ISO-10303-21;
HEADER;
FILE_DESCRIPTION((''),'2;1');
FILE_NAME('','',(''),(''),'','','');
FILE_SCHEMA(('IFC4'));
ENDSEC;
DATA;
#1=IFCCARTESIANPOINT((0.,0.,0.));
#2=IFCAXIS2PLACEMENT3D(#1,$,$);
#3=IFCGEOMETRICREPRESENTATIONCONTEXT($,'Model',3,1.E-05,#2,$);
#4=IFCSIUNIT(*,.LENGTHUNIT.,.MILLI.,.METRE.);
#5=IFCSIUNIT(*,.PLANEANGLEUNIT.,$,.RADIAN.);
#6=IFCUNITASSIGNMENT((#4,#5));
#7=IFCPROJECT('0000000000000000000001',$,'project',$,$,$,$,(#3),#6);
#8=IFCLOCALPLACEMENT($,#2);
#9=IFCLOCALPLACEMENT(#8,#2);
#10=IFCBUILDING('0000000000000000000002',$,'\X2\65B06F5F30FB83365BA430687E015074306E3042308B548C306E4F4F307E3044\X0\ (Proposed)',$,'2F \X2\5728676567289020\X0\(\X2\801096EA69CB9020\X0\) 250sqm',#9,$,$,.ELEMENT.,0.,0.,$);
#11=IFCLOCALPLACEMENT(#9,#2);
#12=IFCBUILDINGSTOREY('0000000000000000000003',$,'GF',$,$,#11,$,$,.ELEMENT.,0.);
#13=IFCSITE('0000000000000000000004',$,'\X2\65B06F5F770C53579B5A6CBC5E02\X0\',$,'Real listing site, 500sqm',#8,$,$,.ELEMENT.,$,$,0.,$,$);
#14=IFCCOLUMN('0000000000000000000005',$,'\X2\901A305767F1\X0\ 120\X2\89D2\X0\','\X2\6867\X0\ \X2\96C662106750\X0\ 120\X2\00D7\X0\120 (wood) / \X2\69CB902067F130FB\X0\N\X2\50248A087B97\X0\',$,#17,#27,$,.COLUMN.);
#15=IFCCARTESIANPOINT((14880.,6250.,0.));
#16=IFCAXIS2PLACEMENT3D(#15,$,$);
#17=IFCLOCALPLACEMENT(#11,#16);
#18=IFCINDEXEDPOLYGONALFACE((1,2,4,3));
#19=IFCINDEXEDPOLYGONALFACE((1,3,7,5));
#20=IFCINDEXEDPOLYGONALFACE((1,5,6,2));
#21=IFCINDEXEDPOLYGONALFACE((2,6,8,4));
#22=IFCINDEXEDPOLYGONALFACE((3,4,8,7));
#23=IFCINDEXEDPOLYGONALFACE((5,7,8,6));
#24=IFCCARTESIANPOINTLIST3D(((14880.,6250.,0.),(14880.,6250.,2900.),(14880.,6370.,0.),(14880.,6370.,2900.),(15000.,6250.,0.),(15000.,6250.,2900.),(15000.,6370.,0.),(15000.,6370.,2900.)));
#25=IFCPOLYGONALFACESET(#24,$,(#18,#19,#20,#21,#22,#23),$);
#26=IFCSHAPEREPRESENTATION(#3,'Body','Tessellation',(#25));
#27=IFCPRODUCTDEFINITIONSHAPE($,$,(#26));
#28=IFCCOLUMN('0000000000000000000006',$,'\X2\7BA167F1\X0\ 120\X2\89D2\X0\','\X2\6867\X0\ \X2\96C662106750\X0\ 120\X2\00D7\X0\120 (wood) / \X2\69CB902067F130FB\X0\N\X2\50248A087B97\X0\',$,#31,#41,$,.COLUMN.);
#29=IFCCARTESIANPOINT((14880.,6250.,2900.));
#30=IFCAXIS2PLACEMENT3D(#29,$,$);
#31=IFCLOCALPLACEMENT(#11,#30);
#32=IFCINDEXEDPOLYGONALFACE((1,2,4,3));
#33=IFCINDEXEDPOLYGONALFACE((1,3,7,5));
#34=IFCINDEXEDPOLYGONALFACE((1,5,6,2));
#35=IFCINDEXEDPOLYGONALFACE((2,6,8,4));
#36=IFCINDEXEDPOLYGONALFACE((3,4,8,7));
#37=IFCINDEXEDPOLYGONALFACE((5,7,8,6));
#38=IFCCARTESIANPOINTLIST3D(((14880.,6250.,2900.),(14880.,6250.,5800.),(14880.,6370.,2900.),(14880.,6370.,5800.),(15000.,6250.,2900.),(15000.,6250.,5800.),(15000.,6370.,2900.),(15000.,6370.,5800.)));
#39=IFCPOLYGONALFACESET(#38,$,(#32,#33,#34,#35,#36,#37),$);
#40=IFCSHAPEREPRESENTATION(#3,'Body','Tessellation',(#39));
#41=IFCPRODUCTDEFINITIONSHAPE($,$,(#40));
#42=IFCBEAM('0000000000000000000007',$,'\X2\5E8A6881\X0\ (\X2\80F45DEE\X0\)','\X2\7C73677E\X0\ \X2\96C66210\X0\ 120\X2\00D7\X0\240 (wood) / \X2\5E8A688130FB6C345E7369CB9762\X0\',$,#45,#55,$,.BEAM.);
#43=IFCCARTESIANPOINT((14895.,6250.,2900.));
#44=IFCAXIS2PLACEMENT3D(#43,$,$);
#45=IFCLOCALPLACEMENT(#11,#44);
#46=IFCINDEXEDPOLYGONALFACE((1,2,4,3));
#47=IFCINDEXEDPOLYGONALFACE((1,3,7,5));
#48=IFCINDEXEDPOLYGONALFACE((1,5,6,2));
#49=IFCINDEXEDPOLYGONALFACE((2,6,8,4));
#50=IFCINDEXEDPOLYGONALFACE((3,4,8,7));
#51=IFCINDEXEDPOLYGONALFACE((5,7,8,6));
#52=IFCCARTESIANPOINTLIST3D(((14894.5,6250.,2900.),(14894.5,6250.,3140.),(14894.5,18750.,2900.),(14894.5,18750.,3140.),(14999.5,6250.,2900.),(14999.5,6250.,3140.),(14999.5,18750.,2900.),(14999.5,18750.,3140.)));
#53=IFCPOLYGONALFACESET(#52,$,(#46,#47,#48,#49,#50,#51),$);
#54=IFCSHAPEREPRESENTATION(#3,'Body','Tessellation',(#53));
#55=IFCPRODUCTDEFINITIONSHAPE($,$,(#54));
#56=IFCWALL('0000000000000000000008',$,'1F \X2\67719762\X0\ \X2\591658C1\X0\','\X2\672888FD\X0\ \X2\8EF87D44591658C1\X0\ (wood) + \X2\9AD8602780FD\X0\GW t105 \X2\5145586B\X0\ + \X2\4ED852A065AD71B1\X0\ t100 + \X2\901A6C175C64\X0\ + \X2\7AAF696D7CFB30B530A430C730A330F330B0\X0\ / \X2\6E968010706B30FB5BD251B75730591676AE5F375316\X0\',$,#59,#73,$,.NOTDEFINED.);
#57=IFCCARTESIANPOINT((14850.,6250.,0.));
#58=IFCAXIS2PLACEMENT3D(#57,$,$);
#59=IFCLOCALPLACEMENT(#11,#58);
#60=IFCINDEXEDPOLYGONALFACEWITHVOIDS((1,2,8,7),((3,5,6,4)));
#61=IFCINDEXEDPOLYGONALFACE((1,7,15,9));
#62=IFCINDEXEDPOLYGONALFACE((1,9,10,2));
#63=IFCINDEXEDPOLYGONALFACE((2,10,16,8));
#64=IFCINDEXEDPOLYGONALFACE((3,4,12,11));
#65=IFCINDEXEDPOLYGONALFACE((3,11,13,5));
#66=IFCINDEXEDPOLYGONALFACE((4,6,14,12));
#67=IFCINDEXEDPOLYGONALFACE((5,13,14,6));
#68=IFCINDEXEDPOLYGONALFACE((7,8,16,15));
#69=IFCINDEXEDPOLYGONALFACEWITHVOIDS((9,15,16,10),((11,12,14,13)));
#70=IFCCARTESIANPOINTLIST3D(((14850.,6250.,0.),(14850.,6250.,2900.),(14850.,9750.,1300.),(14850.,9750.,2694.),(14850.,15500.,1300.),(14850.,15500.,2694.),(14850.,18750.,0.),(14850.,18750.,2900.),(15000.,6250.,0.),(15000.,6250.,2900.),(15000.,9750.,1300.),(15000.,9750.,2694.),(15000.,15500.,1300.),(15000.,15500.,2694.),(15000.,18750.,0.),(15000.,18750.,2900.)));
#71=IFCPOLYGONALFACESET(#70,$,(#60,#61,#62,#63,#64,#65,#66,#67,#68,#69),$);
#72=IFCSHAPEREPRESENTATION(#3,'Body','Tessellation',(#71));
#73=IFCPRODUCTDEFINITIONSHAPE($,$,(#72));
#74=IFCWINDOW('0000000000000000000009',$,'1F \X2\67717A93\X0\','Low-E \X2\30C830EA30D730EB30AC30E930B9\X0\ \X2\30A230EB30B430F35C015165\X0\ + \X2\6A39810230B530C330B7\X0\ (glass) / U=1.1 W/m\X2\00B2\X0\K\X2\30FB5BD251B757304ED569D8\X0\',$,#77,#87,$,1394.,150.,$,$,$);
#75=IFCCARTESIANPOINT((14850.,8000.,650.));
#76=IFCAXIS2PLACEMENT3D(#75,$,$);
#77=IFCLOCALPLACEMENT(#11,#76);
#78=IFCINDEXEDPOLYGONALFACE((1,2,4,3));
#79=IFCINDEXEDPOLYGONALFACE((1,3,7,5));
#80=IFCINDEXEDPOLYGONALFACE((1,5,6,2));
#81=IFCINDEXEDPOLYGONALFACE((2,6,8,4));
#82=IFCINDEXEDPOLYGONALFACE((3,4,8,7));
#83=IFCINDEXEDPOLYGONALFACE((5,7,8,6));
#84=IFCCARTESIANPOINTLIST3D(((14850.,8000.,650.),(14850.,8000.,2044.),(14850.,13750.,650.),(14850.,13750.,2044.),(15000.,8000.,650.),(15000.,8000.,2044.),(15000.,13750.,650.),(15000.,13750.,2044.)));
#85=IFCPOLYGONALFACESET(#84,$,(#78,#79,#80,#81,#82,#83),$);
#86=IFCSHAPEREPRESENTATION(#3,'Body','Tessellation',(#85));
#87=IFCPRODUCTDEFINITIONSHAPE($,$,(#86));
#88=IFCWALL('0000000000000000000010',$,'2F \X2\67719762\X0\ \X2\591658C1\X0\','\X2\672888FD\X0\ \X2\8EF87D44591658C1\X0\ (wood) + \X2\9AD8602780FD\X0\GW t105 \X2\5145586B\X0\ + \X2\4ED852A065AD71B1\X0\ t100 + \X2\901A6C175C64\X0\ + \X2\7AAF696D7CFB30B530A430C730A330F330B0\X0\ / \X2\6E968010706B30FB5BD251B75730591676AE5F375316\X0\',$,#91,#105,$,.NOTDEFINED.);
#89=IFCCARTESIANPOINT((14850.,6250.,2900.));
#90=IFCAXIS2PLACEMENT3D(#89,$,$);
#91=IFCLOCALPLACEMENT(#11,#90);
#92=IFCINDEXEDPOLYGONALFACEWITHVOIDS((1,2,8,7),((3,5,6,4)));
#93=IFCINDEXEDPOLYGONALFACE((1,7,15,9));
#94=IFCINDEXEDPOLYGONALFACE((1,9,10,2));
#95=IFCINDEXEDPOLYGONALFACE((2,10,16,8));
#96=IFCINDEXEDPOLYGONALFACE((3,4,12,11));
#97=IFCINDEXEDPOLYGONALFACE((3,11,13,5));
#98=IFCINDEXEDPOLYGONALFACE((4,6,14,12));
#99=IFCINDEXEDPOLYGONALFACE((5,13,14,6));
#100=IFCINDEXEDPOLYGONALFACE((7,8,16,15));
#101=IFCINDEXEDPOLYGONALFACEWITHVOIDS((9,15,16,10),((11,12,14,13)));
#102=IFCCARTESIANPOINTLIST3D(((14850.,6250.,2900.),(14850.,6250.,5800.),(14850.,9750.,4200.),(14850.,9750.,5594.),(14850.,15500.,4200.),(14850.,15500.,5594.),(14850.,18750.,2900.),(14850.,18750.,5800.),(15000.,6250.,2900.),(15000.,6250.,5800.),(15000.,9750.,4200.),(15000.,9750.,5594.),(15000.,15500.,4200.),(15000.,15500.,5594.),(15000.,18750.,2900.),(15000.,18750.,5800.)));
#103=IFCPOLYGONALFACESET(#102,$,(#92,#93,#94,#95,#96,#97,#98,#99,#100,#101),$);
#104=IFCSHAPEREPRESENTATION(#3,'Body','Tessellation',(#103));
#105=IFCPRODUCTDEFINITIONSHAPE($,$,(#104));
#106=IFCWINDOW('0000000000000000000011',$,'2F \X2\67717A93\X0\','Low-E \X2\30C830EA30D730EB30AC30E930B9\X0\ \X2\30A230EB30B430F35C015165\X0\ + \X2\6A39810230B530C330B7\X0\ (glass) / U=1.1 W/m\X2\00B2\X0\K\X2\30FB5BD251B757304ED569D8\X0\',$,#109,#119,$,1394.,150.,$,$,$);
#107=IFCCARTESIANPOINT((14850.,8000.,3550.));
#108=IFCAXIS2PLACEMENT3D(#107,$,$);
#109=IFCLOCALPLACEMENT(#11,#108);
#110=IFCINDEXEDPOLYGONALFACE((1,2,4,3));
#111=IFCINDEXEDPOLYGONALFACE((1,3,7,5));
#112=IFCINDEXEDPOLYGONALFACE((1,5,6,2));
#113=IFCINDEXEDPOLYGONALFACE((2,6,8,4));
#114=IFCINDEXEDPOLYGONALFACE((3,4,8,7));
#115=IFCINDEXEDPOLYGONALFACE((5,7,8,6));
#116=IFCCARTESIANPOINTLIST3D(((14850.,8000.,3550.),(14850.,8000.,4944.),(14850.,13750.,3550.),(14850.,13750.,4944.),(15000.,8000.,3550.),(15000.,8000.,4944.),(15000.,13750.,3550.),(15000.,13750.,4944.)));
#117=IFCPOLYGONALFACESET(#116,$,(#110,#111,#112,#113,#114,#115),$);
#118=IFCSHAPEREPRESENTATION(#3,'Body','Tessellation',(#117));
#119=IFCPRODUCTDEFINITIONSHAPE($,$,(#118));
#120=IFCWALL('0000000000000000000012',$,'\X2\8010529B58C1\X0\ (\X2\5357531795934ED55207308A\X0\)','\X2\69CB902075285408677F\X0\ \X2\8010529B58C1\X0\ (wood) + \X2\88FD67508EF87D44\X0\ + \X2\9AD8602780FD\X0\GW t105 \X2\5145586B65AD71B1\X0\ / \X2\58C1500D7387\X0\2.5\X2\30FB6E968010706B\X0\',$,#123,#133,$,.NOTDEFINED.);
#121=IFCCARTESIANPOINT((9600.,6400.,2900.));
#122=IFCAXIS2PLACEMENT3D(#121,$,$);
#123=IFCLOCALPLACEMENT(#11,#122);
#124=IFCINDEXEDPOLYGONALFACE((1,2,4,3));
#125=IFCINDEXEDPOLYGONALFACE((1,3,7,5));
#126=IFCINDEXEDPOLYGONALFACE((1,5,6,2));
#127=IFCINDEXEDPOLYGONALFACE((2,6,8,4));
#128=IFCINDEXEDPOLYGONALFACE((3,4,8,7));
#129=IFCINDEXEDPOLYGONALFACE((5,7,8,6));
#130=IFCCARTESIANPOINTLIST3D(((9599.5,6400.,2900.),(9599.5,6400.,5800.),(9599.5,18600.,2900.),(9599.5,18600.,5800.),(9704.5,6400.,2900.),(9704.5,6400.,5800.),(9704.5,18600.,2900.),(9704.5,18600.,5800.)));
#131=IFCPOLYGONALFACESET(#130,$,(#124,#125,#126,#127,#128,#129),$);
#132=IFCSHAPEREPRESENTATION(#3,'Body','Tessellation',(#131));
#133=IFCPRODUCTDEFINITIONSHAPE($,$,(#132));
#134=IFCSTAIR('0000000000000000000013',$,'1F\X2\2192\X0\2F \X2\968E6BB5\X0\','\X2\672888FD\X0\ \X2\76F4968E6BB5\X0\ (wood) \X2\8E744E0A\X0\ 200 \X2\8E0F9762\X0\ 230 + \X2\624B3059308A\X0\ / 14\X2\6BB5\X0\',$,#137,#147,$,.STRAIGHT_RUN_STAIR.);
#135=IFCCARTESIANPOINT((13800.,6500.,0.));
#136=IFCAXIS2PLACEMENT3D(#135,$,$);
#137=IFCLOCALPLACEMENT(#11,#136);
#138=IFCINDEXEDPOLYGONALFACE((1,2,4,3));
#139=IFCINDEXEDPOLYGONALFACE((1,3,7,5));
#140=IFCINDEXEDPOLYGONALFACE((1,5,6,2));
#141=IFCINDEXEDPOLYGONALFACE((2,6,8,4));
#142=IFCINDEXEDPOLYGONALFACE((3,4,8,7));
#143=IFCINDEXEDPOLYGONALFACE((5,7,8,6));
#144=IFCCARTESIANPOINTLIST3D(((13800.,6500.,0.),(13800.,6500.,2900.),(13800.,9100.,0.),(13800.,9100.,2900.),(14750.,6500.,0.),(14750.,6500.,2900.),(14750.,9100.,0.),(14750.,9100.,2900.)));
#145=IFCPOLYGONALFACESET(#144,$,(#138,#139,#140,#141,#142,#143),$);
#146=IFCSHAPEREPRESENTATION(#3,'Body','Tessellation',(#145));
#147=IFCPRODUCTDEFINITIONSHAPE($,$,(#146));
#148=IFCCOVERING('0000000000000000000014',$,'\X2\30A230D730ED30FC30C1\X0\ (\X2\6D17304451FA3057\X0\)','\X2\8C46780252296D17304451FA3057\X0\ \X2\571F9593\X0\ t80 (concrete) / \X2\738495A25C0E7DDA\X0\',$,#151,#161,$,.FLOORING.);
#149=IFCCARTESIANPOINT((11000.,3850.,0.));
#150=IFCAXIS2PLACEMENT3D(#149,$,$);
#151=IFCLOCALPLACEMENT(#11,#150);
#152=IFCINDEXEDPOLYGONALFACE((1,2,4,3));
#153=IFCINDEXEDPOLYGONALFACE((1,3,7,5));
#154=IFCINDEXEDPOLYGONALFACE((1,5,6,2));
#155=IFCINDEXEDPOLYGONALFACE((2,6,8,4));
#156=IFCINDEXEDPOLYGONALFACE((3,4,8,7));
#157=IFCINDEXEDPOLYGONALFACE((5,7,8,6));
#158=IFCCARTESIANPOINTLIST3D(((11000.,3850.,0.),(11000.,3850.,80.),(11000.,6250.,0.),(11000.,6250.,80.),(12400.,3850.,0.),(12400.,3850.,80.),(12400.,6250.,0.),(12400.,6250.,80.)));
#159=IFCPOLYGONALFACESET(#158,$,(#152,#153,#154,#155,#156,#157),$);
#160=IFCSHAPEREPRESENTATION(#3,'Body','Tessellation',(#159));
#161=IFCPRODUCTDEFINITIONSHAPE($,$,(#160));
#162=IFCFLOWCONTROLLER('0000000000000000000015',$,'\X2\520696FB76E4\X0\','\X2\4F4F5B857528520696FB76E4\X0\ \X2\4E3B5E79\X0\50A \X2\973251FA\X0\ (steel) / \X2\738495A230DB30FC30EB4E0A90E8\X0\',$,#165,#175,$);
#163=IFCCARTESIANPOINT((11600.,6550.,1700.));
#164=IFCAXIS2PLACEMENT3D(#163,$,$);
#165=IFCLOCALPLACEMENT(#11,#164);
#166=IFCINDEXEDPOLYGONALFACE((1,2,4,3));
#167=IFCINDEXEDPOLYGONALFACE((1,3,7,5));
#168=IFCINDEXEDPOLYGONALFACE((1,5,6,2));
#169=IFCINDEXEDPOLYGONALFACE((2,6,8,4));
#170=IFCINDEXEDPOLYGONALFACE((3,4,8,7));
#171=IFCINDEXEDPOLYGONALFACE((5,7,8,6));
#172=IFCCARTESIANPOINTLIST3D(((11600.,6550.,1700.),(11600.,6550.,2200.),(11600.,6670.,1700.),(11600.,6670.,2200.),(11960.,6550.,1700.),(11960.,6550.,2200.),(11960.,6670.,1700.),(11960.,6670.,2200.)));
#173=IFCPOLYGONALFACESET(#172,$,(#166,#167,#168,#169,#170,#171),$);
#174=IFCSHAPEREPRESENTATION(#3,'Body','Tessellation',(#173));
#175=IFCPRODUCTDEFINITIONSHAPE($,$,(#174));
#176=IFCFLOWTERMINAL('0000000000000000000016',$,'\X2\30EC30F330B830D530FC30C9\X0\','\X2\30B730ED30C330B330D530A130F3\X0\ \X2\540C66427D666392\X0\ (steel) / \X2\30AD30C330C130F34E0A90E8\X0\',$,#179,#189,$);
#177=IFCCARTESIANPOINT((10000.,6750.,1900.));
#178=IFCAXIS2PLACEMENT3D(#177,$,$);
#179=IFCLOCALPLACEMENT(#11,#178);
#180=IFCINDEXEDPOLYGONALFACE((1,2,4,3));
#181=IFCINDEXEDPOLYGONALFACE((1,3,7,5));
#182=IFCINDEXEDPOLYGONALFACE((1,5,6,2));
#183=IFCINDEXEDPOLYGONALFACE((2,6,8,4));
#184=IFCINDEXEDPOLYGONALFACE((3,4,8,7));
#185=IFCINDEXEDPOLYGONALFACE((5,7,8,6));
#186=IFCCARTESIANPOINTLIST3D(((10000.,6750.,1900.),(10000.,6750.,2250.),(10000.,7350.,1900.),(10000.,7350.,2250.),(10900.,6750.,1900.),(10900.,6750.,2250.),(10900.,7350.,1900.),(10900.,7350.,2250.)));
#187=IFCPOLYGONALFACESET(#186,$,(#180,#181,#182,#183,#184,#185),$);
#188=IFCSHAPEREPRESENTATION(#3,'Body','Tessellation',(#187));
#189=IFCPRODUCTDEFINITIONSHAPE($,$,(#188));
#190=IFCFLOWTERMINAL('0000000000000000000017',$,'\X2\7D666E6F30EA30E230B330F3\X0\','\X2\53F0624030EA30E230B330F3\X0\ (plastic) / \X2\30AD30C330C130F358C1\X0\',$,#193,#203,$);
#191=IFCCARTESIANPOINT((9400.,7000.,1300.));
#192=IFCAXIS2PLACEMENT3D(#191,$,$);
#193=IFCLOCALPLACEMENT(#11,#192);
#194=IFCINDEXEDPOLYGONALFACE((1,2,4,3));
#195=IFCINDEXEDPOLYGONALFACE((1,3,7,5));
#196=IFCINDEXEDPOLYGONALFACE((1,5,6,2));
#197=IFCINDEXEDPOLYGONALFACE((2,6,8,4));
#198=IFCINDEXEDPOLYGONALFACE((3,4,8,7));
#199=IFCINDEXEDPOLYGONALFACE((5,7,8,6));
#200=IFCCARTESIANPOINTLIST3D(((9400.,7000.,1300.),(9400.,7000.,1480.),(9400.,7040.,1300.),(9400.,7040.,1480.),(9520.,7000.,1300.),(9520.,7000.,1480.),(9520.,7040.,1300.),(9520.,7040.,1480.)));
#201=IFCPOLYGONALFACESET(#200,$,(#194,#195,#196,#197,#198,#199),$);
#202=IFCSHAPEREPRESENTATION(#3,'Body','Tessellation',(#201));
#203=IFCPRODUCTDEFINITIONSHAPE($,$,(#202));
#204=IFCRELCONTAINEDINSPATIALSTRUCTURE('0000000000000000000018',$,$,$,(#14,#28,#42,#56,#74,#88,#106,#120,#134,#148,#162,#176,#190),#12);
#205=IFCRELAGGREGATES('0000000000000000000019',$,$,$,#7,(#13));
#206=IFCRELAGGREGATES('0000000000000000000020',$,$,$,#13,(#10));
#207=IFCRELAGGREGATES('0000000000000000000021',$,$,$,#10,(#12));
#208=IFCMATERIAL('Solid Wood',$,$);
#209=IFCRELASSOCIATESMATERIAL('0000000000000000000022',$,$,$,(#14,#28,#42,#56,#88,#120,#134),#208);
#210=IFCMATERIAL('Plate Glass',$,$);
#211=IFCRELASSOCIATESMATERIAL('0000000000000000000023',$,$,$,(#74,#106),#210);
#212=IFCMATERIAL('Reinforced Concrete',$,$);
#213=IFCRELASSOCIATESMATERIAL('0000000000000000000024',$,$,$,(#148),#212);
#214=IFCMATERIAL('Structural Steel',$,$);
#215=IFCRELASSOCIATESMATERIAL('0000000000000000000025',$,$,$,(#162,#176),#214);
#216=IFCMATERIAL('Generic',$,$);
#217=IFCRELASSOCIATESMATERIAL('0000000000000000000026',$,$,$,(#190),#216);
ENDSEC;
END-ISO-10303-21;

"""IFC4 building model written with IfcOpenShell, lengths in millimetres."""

from ifc_helpers import new_model, si_unit, frame, frame_2d, origin, place, context, project, spatial, rectangle, extrude, material, element, fill, save


model = new_model("IFC4")

# Units and contexts
model_context = context("Model", 3, precision=1e-05, world=origin())
ifc_project = project(units=[si_unit("LENGTHUNIT", "METRE", prefix="MILLI"), si_unit("PLANEANGLEUNIT", "RADIAN")], contexts=[model_context])

# Site, building, storey
site_placement = place(None, origin())
site = spatial("IfcSite", under=ifc_project, at=site_placement, Name="新潟県南魚沼市", ObjectType="Real listing site, 500sqm", CompositionType="ELEMENT", RefElevation=0.0)
building_placement = place(site_placement, origin())
building = spatial("IfcBuilding", under=site, at=building_placement, Name="新潟・茶室と縁側のある和の住まい (Proposed)", ObjectType="2F 在来木造(耐雪構造) 250sqm", CompositionType="ELEMENT", ElevationOfRefHeight=0.0, ElevationOfTerrain=0.0)
storey_placement = place(building_placement, origin())
storey = spatial("IfcBuildingStorey", under=building, at=storey_placement, Name="GF", CompositionType="ELEMENT", Elevation=0.0)

# Columns
ifc_material_1 = material(Name="Solid Wood")
column_1_placement = place(storey_placement, frame((14880.0, 6250.0, 0.0)))
element("IfcColumn", 1, at=column_1_placement, inside=storey, material=ifc_material_1, Name="通し柱 120角", Description="桧 集成材 120×120 (wood) / 構造柱・N値計算", PredefinedType="COLUMN", context=model_context, shape_type="SweptSolid", body=[
    extrude(rectangle(XDim=120.0, YDim=120.0, at=frame_2d((60.0, 60.0))), frame((14880.0, 6250.0, 0.0)), (0.0, 0.0, 1.0), 2900.0),
])
column_2_placement = place(storey_placement, frame((14880.0, 6250.0, 2900.0)))
element("IfcColumn", 2, at=column_2_placement, inside=storey, material=ifc_material_1, Name="管柱 120角", Description="桧 集成材 120×120 (wood) / 構造柱・N値計算", PredefinedType="COLUMN", context=model_context, shape_type="SweptSolid", body=[
    extrude(rectangle(XDim=120.0, YDim=120.0, at=frame_2d((60.0, 60.0))), frame((14880.0, 6250.0, 2900.0)), (0.0, 0.0, 1.0), 2900.0),
])

# Beam
beam_1_placement = place(storey_placement, frame((14895.0, 6250.0, 2900.0)))
element("IfcBeam", 3, at=beam_1_placement, inside=storey, material=ifc_material_1, Name="床梁 (胴差)", Description="米松 集成 120×240 (wood) / 床梁・水平構面", PredefinedType="BEAM", context=model_context, shape_type="SweptSolid", body=[
    extrude(rectangle(XDim=105.0, YDim=12500.0, at=frame_2d((52.0, 6250.0))), frame((14895.0, 6250.0, 2900.0)), (0.0, 0.0, 1.0), 240.0),
])

# Wall, opening, window
wall_1_placement = place(storey_placement, frame((14850.0, 6250.0, 0.0)))
wall_1 = element("IfcWall", 4, at=wall_1_placement, inside=storey, material=ifc_material_1, Name="1F 東面 外壁", Description="木製 軸組外壁 (wood) + 高性能GW t105 充填 + 付加断熱 t100 + 通気層 + 窯業系サイディング / 準耐火・寒冷地外皮強化", PredefinedType="NOTDEFINED", context=model_context, shape_type="SweptSolid", body=[
    extrude(rectangle(XDim=150.0, YDim=12500.0, at=frame_2d((75.0, 6250.0))), frame((14850.0, 6250.0, 0.0)), (0.0, 0.0, 1.0), 2900.0),
])
opening_1_placement = place(storey_placement, frame((14850.0, 8000.0, 650.0)))
opening_1 = element("IfcOpeningElement", 5, at=opening_1_placement, cuts=wall_1, PredefinedType="NOTDEFINED", context=model_context, shape_type="SweptSolid", body=[
    extrude(rectangle(XDim=150.0, YDim=5750.0, at=frame_2d((75.0, 2875.0))), frame((14850.0, 8000.0, 650.0)), (0.0, 0.0, 1.0), 1394.0),
])
ifc_material_2 = material(Name="Plate Glass")
window_1_placement = place(storey_placement, frame((14850.0, 8000.0, 650.0)))
window_1 = element("IfcWindow", 6, at=window_1_placement, inside=storey, material=ifc_material_2, Name="1F 東窓", Description="Low-E トリプルガラス アルゴン封入 + 樹脂サッシ (glass) / U=1.1 W/m²K・寒冷地仕様", OverallHeight=1394.0, OverallWidth=150.0, context=model_context, shape_type="SweptSolid", body=[
    extrude(rectangle(XDim=150.0, YDim=5750.0, at=frame_2d((75.0, 2875.0))), frame((14850.0, 8000.0, 650.0)), (0.0, 0.0, 1.0), 1394.0),
])
fill(opening_1, window_1)

# Wall, opening, window
wall_2_placement = place(storey_placement, frame((14850.0, 6250.0, 2900.0)))
wall_2 = element("IfcWall", 7, at=wall_2_placement, inside=storey, material=ifc_material_1, Name="2F 東面 外壁", Description="木製 軸組外壁 (wood) + 高性能GW t105 充填 + 付加断熱 t100 + 通気層 + 窯業系サイディング / 準耐火・寒冷地外皮強化", PredefinedType="NOTDEFINED", context=model_context, shape_type="SweptSolid", body=[
    extrude(rectangle(XDim=150.0, YDim=12500.0, at=frame_2d((75.0, 6250.0))), frame((14850.0, 6250.0, 2900.0)), (0.0, 0.0, 1.0), 2900.0),
])
opening_2_placement = place(storey_placement, frame((14850.0, 8000.0, 3550.0)))
opening_2 = element("IfcOpeningElement", 8, at=opening_2_placement, cuts=wall_2, PredefinedType="NOTDEFINED", context=model_context, shape_type="SweptSolid", body=[
    extrude(rectangle(XDim=150.0, YDim=5750.0, at=frame_2d((75.0, 2875.0))), frame((14850.0, 8000.0, 3550.0)), (0.0, 0.0, 1.0), 1394.0),
])
window_2_placement = place(storey_placement, frame((14850.0, 8000.0, 3550.0)))
window_2 = element("IfcWindow", 9, at=window_2_placement, inside=storey, material=ifc_material_2, Name="2F 東窓", Description="Low-E トリプルガラス アルゴン封入 + 樹脂サッシ (glass) / U=1.1 W/m²K・寒冷地仕様", OverallHeight=1394.0, OverallWidth=150.0, context=model_context, shape_type="SweptSolid", body=[
    extrude(rectangle(XDim=150.0, YDim=5750.0, at=frame_2d((75.0, 2875.0))), frame((14850.0, 8000.0, 3550.0)), (0.0, 0.0, 1.0), 1394.0),
])
fill(opening_2, window_2)

# Wall
wall_3_placement = place(storey_placement, frame((9600.0, 6400.0, 2900.0)))
element("IfcWall", 10, at=wall_3_placement, inside=storey, material=ifc_material_1, Name="耐力壁 (南北間仕切り)", Description="構造用合板 耐力壁 (wood) + 製材軸組 + 高性能GW t105 充填断熱 / 壁倍率2.5・準耐火", PredefinedType="NOTDEFINED", context=model_context, shape_type="SweptSolid", body=[
    extrude(rectangle(XDim=105.0, YDim=12200.0, at=frame_2d((52.0, 6100.0))), frame((9600.0, 6400.0, 2900.0)), (0.0, 0.0, 1.0), 2900.0),
])

# Stair
stair_placement = place(storey_placement, frame((13800.0, 6500.0, 0.0)))
element("IfcStair", 11, at=stair_placement, inside=storey, material=ifc_material_1, Name="1F→2F 階段", Description="木製 直階段 (wood) 蹴上 200 踏面 230 + 手すり / 14段", PredefinedType="STRAIGHT_RUN_STAIR", context=model_context, shape_type="SweptSolid", body=[
    extrude(rectangle(XDim=950.0, YDim=2600.0, at=frame_2d((475.0, 1300.0))), frame((13800.0, 6500.0, 0.0)), (0.0, 0.0, 1.0), 2900.0),
])

# Covering
ifc_material_3 = material(Name="Reinforced Concrete")
covering_placement = place(storey_placement, frame((11000.0, 3850.0, 0.0)))
element("IfcCovering", 12, at=covering_placement, inside=storey, material=ifc_material_3, Name="アプローチ (洗い出し)", Description="豆砂利洗い出し 土間 t80 (concrete) / 玄関導線", PredefinedType="FLOORING", context=model_context, shape_type="SweptSolid", body=[
    extrude(rectangle(XDim=1400.0, YDim=2400.0, at=frame_2d((700.0, 1200.0))), frame((11000.0, 3850.0, 0.0)), (0.0, 0.0, 1.0), 80.0),
])

# Flow controller
ifc_material_4 = material(Name="Structural Steel")
flow_controller_placement = place(storey_placement, frame((11600.0, 6550.0, 1700.0)))
element("IfcFlowController", 13, at=flow_controller_placement, inside=storey, material=ifc_material_4, Name="分電盤", Description="住宅用分電盤 主幹50A 露出 (steel) / 玄関ホール上部", context=model_context, shape_type="SweptSolid", body=[
    extrude(rectangle(XDim=360.0, YDim=120.0, at=frame_2d((180.0, 60.0))), frame((11600.0, 6550.0, 1700.0)), (0.0, 0.0, 1.0), 500.0),
])

# Flow terminals
flow_terminal_1_placement = place(storey_placement, frame((10000.0, 6750.0, 1900.0)))
element("IfcFlowTerminal", 14, at=flow_terminal_1_placement, inside=storey, material=ifc_material_4, Name="レンジフード", Description="シロッコファン 同時給排 (steel) / キッチン上部", context=model_context, shape_type="SweptSolid", body=[
    extrude(rectangle(XDim=900.0, YDim=600.0, at=frame_2d((450.0, 300.0))), frame((10000.0, 6750.0, 1900.0)), (0.0, 0.0, 1.0), 350.0),
])
ifc_material_5 = material(Name="Generic")
flow_terminal_2_placement = place(storey_placement, frame((9400.0, 7000.0, 1300.0)))
element("IfcFlowTerminal", 15, at=flow_terminal_2_placement, inside=storey, material=ifc_material_5, Name="給湯リモコン", Description="台所リモコン (plastic) / キッチン壁", context=model_context, shape_type="SweptSolid", body=[
    extrude(rectangle(XDim=120.0, YDim=40.0, at=frame_2d((60.0, 20.0))), frame((9400.0, 7000.0, 1300.0)), (0.0, 0.0, 1.0), 180.0),
])

save(model, "model.ifc")
